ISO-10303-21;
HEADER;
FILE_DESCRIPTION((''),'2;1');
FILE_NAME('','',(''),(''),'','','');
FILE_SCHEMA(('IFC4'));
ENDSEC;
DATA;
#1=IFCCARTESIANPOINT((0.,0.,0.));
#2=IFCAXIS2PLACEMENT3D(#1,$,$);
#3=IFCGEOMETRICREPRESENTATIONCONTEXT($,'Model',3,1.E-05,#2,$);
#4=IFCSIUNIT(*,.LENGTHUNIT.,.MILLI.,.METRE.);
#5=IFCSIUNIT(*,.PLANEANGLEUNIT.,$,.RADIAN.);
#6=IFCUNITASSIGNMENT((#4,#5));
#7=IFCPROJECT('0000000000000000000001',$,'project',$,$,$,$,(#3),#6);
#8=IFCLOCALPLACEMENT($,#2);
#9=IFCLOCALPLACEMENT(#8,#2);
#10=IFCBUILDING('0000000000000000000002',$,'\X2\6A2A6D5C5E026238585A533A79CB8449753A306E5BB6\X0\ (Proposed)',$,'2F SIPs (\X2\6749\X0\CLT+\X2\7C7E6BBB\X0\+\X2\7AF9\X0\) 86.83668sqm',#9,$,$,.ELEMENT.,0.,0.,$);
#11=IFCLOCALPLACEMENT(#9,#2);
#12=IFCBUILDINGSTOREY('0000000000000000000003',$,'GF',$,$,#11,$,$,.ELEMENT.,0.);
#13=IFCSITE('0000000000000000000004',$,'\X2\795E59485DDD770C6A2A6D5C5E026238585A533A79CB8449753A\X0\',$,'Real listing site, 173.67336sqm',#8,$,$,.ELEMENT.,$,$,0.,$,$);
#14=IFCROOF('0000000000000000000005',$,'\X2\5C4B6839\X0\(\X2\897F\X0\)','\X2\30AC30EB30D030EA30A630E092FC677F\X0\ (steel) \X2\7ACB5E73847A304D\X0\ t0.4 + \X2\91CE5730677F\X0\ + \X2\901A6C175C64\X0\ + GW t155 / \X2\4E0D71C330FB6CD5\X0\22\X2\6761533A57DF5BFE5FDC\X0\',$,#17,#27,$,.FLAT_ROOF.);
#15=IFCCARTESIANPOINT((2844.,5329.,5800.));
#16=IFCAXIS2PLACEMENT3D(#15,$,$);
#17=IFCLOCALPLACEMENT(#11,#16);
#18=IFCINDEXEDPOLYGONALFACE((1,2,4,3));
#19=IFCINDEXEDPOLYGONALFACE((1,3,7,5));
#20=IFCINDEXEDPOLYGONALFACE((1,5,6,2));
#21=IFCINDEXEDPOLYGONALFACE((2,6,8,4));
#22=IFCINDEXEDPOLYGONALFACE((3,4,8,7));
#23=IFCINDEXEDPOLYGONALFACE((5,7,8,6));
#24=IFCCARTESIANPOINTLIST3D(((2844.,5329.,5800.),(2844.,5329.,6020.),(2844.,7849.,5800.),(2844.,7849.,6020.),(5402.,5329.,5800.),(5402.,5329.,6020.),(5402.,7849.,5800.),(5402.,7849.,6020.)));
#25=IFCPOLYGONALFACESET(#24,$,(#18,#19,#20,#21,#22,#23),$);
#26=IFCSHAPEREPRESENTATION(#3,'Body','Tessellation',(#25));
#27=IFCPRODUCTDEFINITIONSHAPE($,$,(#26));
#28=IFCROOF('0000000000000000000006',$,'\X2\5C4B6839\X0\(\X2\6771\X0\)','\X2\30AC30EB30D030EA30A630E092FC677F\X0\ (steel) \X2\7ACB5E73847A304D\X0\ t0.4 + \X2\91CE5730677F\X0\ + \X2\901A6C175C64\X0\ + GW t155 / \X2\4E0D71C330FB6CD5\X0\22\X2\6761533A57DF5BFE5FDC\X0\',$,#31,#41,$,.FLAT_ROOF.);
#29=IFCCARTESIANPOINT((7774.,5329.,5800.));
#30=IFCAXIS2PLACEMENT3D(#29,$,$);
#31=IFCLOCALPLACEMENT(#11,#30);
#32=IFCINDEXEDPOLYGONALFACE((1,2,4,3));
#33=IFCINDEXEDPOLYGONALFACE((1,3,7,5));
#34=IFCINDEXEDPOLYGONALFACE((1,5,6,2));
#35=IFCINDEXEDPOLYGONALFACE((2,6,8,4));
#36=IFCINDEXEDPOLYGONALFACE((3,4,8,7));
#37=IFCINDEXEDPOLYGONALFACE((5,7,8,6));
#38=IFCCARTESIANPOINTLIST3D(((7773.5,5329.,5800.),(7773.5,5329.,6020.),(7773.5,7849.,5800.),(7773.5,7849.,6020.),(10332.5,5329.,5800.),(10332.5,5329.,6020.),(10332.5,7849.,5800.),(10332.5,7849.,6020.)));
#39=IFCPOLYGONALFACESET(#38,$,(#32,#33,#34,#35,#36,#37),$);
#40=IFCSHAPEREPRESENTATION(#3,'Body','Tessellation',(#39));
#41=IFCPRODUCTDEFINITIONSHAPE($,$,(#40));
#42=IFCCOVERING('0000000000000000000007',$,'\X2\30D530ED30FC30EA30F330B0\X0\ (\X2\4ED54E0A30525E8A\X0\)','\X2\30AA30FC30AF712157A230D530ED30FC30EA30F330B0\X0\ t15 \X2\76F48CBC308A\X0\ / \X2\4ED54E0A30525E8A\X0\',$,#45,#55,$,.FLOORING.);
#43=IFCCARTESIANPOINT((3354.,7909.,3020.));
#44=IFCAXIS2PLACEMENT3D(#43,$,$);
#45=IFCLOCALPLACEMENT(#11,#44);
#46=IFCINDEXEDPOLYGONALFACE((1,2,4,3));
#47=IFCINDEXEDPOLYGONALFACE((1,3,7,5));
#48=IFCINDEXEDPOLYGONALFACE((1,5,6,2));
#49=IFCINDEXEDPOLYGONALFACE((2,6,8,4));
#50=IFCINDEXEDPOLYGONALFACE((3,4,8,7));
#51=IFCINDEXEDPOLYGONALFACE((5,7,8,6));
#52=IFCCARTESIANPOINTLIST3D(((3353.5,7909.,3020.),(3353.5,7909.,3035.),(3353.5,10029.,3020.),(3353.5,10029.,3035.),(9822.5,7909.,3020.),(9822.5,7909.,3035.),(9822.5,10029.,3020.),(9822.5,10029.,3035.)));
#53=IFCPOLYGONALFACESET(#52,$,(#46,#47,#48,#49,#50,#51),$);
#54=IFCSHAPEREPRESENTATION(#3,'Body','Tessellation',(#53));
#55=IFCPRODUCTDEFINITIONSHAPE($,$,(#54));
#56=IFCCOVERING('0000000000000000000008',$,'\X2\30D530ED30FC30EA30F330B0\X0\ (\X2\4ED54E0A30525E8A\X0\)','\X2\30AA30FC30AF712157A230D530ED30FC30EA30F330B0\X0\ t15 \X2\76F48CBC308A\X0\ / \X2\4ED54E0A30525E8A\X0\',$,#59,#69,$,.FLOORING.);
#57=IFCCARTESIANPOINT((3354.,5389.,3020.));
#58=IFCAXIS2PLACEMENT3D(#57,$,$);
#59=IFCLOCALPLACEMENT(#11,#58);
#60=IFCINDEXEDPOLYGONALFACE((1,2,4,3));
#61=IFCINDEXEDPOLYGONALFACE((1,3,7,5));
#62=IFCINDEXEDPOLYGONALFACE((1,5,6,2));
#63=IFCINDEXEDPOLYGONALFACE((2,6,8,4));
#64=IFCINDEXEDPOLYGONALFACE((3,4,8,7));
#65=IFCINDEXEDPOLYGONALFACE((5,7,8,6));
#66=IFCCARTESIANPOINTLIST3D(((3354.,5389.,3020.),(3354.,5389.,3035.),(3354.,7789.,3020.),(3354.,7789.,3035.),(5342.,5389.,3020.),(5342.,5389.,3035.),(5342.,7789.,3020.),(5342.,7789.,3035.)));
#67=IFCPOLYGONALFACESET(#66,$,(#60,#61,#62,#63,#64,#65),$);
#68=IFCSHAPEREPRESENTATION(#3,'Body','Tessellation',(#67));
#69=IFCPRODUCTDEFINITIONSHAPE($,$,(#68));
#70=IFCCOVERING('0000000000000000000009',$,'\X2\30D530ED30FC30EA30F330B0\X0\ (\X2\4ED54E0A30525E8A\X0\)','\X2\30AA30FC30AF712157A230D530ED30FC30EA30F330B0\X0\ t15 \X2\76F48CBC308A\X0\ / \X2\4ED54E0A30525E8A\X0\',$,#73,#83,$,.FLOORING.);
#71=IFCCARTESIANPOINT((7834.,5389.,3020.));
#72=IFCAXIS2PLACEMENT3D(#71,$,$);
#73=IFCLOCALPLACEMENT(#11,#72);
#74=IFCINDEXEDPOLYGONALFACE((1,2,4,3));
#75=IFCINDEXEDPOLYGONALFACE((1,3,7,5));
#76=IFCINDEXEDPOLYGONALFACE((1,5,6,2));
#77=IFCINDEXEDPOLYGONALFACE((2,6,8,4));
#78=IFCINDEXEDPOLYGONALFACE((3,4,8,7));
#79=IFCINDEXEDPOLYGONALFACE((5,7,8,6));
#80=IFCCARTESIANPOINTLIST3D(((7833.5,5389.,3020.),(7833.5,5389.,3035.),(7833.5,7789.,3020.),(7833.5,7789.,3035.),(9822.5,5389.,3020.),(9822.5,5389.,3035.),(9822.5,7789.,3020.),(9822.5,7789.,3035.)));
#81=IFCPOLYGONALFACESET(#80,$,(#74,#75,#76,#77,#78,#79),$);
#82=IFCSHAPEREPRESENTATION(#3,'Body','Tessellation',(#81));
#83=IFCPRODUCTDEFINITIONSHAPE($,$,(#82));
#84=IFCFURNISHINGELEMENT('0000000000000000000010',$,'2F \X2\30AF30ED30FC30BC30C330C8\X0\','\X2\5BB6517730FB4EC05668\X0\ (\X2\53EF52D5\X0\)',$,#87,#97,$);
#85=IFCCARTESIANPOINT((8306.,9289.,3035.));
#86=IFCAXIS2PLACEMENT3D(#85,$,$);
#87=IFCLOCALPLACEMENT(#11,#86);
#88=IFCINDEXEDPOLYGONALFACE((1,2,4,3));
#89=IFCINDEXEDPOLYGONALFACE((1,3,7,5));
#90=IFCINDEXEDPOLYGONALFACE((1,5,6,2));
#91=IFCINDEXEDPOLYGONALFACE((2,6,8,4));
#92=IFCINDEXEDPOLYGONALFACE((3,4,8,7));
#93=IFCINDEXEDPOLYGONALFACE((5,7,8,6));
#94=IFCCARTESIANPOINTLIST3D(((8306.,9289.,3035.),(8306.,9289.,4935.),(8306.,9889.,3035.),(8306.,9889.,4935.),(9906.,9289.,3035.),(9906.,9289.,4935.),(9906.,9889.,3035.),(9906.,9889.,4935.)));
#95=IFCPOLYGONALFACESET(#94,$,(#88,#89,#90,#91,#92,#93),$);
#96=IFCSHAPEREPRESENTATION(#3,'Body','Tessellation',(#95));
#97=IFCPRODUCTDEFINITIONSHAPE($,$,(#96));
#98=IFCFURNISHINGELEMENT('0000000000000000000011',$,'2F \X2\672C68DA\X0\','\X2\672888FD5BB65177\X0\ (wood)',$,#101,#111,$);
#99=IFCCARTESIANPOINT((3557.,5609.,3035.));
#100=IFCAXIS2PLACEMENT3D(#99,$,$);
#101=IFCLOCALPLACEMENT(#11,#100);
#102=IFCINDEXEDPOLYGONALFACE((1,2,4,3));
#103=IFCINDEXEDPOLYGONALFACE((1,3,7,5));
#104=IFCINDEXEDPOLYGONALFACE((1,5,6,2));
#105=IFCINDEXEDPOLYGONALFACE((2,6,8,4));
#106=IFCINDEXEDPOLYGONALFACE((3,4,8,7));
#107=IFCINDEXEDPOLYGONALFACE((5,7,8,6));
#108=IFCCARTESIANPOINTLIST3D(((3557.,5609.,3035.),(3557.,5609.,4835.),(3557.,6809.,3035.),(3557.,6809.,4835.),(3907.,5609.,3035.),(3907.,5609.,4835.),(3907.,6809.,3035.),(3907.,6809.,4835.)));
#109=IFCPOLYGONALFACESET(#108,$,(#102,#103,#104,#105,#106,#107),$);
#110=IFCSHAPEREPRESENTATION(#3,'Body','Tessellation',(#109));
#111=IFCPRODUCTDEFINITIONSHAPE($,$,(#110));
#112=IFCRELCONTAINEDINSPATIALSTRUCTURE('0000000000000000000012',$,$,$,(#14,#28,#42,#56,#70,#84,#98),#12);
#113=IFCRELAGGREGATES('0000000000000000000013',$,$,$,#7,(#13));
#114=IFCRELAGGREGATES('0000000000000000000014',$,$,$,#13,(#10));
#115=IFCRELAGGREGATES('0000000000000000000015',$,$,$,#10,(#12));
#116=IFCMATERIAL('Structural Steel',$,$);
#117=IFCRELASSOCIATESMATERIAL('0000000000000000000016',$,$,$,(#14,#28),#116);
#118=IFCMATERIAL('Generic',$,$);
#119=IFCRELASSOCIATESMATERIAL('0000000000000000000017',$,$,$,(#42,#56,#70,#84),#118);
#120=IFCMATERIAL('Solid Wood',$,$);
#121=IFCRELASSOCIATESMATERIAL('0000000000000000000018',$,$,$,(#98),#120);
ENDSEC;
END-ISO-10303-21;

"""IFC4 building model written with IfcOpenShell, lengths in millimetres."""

from ifc_helpers import new_model, si_unit, frame, frame_2d, origin, place, context, project, spatial, rectangle, extrude, material, element, save


model = new_model("IFC4")

# Units and contexts
model_context = context("Model", 3, precision=1e-05, world=origin())
ifc_project = project(units=[si_unit("LENGTHUNIT", "METRE", prefix="MILLI"), si_unit("PLANEANGLEUNIT", "RADIAN")], contexts=[model_context])

# Site, building, storey
site_placement = place(None, origin())
site = spatial("IfcSite", under=ifc_project, at=site_placement, Name="神奈川県横浜市戸塚区秋葉町", ObjectType="Real listing site, 173.67336sqm", CompositionType="ELEMENT", RefElevation=0.0)
building_placement = place(site_placement, origin())
building = spatial("IfcBuilding", under=site, at=building_placement, Name="横浜市戸塚区秋葉町の家 (Proposed)", ObjectType="2F SIPs (杉CLT+籾殻+竹) 86.83668sqm", CompositionType="ELEMENT", ElevationOfRefHeight=0.0, ElevationOfTerrain=0.0)
storey_placement = place(building_placement, origin())
storey = spatial("IfcBuildingStorey", under=building, at=storey_placement, Name="GF", CompositionType="ELEMENT", Elevation=0.0)

# Shared definitions
ifc_material_1 = material(Name="Solid Wood")

# Roofs
ifc_material_2 = material(Name="Structural Steel")
roof_1_placement = place(storey_placement, frame((2844.0, 5329.0, 5800.0)))
element("IfcRoof", 1, at=roof_1_placement, inside=storey, material=ifc_material_2, Name="屋根(西)", Description="ガルバリウム鋼板 (steel) 立平葺き t0.4 + 野地板 + 通気層 + GW t155 / 不燃・法22条区域対応", PredefinedType="FLAT_ROOF", context=model_context, shape_type="SweptSolid", body=[
    extrude(rectangle(XDim=2558.0, YDim=2520.0, at=frame_2d((1279.0, 1260.0))), frame((2844.0, 5329.0, 5800.0)), (0.0, 0.0, 1.0), 220.0),
])
roof_2_placement = place(storey_placement, frame((7774.0, 5329.0, 5800.0)))
element("IfcRoof", 2, at=roof_2_placement, inside=storey, material=ifc_material_2, Name="屋根(東)", Description="ガルバリウム鋼板 (steel) 立平葺き t0.4 + 野地板 + 通気層 + GW t155 / 不燃・法22条区域対応", PredefinedType="FLAT_ROOF", context=model_context, shape_type="SweptSolid", body=[
    extrude(rectangle(XDim=2559.0, YDim=2520.0, at=frame_2d((1279.0, 1260.0))), frame((7774.0, 5329.0, 5800.0)), (0.0, 0.0, 1.0), 220.0),
])

# Coverings
ifc_material_3 = material(Name="Generic")
covering_1_placement = place(storey_placement, frame((3354.0, 7909.0, 3020.0)))
element("IfcCovering", 3, at=covering_1_placement, inside=storey, material=ifc_material_3, Name="フローリング (仕上げ床)", Description="オーク無垢フローリング t15 直貼り / 仕上げ床", PredefinedType="FLOORING", context=model_context, shape_type="SweptSolid", body=[
    extrude(rectangle(XDim=6469.0, YDim=2120.0, at=frame_2d((3234.0, 1060.0))), frame((3354.0, 7909.0, 3020.0)), (0.0, 0.0, 1.0), 15.0),
])
covering_2_placement = place(storey_placement, frame((3354.0, 5389.0, 3020.0)))
element("IfcCovering", 4, at=covering_2_placement, inside=storey, material=ifc_material_3, Name="フローリング (仕上げ床)", Description="オーク無垢フローリング t15 直貼り / 仕上げ床", PredefinedType="FLOORING", context=model_context, shape_type="SweptSolid", body=[
    extrude(rectangle(XDim=1988.0, YDim=2400.0, at=frame_2d((994.0, 1200.0))), frame((3354.0, 5389.0, 3020.0)), (0.0, 0.0, 1.0), 15.0),
])
covering_3_placement = place(storey_placement, frame((7834.0, 5389.0, 3020.0)))
element("IfcCovering", 5, at=covering_3_placement, inside=storey, material=ifc_material_3, Name="フローリング (仕上げ床)", Description="オーク無垢フローリング t15 直貼り / 仕上げ床", PredefinedType="FLOORING", context=model_context, shape_type="SweptSolid", body=[
    extrude(rectangle(XDim=1989.0, YDim=2400.0, at=frame_2d((994.0, 1200.0))), frame((7834.0, 5389.0, 3020.0)), (0.0, 0.0, 1.0), 15.0),
])

# Furnishing elements
furnishing_1_placement = place(storey_placement, frame((8306.0, 9289.0, 3035.0)))
element("IfcFurnishingElement", 6, at=furnishing_1_placement, inside=storey, material=ifc_material_3, Name="2F クローゼット", Description="家具・什器 (可動)", context=model_context, shape_type="SweptSolid", body=[
    extrude(rectangle(XDim=1600.0, YDim=600.0, at=frame_2d((800.0, 300.0))), frame((8306.0, 9289.0, 3035.0)), (0.0, 0.0, 1.0), 1900.0),
])
furnishing_2_placement = place(storey_placement, frame((3557.0, 5609.0, 3035.0)))
element("IfcFurnishingElement", 7, at=furnishing_2_placement, inside=storey, material=ifc_material_1, Name="2F 本棚", Description="木製家具 (wood)", context=model_context, shape_type="SweptSolid", body=[
    extrude(rectangle(XDim=350.0, YDim=1200.0, at=frame_2d((175.0, 600.0))), frame((3557.0, 5609.0, 3035.0)), (0.0, 0.0, 1.0), 1800.0),
])

save(model, "model.ifc")
